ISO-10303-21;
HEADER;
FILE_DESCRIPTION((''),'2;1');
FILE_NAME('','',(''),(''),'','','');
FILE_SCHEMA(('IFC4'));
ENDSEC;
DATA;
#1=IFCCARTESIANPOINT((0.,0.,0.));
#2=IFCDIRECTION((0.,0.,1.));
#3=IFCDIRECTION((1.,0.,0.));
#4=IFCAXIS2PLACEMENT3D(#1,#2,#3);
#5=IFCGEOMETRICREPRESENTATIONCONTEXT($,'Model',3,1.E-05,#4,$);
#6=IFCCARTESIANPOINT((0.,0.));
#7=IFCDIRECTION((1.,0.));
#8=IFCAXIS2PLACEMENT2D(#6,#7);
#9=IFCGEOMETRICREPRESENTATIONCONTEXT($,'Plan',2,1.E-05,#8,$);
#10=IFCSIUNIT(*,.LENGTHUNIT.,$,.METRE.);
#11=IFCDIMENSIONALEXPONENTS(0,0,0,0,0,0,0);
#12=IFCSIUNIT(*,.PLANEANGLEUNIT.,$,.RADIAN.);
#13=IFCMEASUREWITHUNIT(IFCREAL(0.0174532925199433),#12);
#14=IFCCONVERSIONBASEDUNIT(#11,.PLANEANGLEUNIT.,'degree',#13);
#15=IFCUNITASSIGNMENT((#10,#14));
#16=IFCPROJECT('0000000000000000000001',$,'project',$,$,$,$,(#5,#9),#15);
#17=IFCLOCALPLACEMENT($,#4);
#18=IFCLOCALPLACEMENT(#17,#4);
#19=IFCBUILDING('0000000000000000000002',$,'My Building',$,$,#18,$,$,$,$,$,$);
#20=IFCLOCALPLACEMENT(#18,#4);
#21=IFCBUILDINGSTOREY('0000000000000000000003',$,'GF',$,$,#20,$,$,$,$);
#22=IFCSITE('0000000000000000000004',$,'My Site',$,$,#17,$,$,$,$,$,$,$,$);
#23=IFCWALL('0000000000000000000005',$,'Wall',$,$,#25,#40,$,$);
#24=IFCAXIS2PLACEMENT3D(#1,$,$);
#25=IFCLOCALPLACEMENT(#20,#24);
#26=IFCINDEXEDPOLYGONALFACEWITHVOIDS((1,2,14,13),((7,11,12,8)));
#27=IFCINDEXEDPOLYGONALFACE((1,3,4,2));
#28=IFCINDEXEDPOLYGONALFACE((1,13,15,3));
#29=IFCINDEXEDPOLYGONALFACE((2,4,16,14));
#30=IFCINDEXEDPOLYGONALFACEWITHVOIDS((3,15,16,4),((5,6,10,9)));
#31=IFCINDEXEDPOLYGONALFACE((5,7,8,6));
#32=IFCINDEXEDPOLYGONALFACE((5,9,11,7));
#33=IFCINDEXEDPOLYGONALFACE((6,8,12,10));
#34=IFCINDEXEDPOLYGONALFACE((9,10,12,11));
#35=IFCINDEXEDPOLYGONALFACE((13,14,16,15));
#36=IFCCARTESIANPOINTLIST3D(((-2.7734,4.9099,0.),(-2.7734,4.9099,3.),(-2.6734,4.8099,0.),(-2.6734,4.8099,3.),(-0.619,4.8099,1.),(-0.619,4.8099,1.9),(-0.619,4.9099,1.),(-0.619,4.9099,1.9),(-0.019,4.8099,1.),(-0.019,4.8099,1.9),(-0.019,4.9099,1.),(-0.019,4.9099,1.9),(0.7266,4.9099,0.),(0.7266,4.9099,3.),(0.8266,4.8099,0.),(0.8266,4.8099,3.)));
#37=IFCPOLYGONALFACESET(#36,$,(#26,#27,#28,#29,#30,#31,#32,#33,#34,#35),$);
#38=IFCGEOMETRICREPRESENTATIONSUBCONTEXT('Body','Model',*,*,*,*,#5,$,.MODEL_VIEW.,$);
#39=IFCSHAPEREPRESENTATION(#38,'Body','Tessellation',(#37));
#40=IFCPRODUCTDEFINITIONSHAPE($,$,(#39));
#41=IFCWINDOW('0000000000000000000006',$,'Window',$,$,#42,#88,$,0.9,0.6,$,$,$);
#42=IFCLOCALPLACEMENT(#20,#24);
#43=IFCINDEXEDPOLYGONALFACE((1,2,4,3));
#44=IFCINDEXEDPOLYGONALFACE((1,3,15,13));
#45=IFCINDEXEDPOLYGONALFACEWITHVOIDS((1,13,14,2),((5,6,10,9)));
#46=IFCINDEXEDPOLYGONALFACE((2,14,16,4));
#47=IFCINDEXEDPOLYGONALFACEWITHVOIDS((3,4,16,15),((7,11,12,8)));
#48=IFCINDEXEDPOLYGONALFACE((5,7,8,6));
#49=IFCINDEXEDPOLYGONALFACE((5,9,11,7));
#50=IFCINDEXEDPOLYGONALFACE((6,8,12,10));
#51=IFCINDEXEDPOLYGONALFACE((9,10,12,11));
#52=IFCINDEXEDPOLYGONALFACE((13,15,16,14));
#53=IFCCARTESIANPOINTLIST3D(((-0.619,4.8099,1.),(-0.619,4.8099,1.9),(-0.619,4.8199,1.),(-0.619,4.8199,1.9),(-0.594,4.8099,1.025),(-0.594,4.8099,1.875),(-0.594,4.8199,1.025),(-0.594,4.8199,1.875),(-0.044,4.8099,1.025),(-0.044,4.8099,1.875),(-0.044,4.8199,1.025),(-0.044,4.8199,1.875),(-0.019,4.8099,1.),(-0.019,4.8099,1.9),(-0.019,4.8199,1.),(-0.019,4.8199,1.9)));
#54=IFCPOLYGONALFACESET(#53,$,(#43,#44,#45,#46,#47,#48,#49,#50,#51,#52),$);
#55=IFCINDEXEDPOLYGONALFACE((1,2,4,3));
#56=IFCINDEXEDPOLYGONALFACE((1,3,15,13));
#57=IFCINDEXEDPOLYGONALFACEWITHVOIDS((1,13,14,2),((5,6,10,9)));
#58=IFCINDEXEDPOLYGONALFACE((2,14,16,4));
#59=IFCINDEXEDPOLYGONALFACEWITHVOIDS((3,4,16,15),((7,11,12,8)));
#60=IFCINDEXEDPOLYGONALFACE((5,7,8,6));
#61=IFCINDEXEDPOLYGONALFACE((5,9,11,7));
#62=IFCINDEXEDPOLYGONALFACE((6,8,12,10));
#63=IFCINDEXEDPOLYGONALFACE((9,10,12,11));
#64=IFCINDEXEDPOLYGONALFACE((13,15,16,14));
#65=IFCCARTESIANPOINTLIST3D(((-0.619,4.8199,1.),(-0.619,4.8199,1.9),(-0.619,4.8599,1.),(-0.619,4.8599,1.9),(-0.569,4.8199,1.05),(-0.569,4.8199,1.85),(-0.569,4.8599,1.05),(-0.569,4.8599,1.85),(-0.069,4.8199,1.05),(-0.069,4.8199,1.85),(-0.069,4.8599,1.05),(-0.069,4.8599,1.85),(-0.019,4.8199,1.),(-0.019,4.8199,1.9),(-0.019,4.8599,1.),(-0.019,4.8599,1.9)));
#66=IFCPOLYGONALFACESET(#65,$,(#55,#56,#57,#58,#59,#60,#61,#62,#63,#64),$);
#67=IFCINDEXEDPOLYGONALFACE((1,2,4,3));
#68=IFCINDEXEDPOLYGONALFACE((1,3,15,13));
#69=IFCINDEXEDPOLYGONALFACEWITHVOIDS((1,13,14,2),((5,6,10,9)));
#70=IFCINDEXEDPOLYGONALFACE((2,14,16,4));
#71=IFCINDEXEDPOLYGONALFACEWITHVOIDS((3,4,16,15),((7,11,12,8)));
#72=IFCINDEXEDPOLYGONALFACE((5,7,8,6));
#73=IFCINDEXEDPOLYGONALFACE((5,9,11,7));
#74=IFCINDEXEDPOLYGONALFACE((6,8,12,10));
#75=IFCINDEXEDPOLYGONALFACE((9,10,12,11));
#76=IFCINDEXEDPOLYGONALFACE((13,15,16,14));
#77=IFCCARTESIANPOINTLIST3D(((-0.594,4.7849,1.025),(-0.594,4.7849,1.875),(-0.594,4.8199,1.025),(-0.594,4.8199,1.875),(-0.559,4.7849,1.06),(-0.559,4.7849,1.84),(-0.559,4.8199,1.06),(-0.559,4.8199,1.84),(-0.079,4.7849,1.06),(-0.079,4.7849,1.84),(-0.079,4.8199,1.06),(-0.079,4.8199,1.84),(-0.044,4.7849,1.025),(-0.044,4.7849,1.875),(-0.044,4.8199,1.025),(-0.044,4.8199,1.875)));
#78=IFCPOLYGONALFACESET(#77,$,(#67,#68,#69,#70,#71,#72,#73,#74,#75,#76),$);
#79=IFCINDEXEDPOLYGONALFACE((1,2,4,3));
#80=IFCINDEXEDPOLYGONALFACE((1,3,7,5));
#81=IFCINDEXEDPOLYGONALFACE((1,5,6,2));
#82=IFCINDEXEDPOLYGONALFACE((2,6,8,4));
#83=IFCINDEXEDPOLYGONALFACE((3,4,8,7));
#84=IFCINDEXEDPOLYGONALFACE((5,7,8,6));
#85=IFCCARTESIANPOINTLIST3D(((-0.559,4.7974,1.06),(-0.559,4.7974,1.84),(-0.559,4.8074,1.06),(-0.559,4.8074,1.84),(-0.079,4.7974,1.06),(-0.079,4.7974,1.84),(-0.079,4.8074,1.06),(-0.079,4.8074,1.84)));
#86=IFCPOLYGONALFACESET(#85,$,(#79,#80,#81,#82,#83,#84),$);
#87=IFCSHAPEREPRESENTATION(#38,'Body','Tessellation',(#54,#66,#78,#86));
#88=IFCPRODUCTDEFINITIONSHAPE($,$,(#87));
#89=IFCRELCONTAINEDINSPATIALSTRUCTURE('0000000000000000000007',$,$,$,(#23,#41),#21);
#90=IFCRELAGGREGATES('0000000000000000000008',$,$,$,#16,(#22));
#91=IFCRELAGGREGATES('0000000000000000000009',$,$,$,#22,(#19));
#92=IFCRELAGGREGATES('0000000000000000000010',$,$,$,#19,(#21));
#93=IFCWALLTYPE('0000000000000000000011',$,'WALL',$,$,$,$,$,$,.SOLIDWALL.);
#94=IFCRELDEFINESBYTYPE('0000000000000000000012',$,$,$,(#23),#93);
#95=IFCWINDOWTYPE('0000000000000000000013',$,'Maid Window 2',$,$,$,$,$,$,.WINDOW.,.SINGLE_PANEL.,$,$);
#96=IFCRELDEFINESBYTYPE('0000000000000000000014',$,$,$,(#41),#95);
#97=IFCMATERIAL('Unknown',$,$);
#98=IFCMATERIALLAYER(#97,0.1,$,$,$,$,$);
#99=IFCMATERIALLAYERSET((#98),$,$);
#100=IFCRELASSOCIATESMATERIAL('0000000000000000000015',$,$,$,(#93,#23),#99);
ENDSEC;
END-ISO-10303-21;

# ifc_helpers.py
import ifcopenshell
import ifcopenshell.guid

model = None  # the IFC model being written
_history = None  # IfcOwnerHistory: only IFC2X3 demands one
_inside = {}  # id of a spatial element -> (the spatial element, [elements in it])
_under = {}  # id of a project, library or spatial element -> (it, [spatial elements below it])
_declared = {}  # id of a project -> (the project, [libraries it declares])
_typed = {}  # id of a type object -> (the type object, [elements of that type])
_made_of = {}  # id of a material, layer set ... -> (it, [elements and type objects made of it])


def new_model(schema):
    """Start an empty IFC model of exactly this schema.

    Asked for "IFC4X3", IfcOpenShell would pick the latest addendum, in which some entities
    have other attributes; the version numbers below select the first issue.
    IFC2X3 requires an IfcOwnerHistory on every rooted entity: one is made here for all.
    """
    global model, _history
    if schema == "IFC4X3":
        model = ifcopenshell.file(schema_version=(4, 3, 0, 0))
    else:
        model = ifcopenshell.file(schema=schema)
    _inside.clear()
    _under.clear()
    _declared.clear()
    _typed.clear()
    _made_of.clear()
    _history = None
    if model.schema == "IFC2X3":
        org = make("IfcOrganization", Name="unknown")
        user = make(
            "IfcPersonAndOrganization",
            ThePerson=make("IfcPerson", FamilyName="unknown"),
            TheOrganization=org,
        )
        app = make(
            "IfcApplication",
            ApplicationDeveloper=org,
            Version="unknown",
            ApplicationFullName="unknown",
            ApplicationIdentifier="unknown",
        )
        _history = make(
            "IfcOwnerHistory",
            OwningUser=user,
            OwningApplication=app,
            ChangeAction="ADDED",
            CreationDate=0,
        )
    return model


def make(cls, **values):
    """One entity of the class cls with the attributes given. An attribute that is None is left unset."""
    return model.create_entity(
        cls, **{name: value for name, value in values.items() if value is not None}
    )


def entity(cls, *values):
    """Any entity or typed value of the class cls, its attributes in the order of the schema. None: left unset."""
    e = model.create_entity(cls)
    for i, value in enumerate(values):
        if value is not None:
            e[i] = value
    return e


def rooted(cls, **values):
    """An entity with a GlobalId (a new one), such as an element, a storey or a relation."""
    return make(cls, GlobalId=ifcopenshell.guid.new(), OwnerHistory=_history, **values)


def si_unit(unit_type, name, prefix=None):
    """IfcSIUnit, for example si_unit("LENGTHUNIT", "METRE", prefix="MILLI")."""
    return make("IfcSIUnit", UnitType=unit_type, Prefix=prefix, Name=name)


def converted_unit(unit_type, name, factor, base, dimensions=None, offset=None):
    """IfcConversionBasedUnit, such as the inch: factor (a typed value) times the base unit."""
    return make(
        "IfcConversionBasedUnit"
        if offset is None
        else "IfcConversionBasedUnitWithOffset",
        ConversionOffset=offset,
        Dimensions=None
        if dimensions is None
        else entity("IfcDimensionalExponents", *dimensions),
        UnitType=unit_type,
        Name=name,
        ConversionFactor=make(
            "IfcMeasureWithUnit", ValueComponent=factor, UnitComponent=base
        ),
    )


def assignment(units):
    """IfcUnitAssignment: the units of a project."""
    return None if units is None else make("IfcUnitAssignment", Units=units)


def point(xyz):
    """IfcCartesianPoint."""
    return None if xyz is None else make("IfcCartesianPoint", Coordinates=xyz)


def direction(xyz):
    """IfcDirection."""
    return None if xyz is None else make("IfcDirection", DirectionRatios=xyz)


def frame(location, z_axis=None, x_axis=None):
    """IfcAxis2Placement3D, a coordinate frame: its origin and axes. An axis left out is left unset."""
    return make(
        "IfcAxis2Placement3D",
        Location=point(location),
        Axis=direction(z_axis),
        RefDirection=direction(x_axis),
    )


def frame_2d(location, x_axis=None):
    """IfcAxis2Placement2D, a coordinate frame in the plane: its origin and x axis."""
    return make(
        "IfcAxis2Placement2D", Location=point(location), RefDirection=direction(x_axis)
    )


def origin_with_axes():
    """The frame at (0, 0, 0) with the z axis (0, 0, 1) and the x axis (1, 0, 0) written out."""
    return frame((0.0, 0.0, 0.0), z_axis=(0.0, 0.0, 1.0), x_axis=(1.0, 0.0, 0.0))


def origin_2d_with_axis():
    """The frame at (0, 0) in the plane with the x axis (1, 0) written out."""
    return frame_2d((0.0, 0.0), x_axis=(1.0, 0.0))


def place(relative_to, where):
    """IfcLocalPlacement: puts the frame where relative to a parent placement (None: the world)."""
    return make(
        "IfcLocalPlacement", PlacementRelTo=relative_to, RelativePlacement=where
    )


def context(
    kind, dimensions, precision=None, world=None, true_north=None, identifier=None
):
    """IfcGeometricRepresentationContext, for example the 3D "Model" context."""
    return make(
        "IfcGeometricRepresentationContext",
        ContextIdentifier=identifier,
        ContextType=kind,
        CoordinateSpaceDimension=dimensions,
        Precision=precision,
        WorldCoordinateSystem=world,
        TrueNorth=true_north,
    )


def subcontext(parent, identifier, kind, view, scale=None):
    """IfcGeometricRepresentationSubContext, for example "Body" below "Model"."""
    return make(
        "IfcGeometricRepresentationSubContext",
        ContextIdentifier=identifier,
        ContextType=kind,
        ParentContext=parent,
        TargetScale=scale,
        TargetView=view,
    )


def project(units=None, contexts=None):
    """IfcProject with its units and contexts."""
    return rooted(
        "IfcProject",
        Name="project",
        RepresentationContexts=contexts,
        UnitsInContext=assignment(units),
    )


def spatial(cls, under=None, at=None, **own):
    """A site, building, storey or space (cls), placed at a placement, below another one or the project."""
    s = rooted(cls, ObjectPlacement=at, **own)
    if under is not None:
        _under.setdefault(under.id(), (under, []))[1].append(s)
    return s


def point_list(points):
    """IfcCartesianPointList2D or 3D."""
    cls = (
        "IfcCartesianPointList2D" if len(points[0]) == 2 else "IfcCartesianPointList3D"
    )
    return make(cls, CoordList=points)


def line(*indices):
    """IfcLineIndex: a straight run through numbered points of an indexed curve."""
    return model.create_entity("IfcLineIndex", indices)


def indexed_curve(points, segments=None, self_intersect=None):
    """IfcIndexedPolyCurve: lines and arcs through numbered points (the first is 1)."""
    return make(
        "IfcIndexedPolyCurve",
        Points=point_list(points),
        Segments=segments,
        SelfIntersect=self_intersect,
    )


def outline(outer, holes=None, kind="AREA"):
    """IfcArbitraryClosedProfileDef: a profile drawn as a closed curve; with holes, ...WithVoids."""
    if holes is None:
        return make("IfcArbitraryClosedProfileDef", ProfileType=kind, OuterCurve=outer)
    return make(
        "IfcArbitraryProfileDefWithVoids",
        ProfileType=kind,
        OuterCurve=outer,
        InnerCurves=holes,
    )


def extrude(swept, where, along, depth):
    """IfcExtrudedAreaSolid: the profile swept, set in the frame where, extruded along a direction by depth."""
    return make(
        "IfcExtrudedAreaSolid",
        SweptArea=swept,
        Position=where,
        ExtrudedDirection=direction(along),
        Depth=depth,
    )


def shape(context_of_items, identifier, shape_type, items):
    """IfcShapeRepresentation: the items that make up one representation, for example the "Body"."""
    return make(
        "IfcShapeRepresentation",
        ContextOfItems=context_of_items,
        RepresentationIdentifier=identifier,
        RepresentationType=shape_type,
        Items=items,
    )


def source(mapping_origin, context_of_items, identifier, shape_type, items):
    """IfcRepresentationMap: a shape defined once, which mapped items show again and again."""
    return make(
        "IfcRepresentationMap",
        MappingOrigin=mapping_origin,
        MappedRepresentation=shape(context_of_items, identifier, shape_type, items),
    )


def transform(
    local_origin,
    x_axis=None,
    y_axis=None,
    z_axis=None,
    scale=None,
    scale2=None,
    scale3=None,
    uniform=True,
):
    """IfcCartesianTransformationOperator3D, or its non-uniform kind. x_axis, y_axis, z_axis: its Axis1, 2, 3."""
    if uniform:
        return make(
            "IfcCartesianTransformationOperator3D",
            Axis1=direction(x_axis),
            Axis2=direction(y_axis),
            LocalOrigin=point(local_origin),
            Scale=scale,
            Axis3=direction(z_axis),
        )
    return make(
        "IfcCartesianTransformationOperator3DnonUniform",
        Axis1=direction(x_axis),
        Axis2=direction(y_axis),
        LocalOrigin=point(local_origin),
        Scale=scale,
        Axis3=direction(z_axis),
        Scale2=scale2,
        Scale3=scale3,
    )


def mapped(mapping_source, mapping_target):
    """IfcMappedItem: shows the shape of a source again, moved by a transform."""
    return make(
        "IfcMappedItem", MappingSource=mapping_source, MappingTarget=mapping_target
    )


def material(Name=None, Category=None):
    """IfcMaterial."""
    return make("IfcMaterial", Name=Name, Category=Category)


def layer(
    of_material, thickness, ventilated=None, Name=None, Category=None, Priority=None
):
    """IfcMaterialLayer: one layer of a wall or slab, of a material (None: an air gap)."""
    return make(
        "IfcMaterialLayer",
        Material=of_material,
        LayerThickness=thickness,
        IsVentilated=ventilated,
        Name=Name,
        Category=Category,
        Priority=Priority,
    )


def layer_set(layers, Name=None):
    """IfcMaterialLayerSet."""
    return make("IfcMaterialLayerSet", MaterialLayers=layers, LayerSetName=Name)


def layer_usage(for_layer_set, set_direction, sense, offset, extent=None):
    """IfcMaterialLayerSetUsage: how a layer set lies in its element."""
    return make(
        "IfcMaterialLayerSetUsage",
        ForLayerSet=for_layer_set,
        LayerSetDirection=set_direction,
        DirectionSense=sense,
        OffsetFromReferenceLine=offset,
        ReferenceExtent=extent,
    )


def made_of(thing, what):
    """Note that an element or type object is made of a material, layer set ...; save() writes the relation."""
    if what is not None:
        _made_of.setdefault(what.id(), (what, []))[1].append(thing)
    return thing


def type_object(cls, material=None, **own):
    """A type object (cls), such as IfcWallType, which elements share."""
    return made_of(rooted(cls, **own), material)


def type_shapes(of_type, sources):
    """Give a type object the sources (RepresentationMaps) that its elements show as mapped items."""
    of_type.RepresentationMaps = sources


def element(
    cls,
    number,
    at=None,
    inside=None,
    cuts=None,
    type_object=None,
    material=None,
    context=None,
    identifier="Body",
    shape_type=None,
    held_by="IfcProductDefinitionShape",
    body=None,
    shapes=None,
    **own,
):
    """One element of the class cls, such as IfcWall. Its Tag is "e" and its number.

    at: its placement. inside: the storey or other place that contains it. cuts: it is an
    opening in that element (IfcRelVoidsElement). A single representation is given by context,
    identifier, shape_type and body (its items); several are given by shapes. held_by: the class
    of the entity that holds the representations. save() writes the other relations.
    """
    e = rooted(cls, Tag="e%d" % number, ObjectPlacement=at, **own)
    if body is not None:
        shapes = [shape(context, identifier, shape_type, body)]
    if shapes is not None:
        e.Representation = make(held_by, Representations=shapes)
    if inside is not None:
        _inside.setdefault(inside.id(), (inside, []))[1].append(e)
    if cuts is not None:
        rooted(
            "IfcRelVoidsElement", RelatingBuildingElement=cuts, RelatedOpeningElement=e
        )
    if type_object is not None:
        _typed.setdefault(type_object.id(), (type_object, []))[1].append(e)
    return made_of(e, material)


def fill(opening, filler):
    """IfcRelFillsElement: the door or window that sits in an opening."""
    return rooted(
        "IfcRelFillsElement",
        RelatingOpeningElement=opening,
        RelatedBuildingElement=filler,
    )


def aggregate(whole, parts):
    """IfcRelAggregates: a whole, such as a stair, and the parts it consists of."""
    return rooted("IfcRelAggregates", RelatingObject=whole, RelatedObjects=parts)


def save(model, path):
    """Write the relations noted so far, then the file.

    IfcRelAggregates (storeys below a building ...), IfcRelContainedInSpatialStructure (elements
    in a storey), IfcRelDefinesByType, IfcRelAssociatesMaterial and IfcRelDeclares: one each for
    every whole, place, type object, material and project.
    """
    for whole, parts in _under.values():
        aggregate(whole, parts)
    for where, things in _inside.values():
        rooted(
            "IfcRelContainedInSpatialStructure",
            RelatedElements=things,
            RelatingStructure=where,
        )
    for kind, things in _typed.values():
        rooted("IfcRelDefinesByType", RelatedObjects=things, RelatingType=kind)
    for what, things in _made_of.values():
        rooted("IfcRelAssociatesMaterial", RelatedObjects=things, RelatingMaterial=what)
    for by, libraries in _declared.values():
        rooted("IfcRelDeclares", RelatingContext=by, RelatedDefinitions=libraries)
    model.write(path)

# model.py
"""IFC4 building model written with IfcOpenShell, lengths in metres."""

from ifc_helpers import new_model, entity, si_unit, converted_unit, frame, origin_with_axes, origin_2d_with_axis, place, context, subcontext, project, spatial, line, indexed_curve, outline, extrude, shape, source, transform, mapped, material, layer, layer_set, layer_usage, type_object, type_shapes, element, fill, save


model = new_model("IFC4")

# Units and contexts
model_context = context("Model", 3, precision=1e-05, world=origin_with_axes())
plan_context = context("Plan", 2, precision=1e-05, world=origin_2d_with_axis())
body_context_1 = subcontext(model_context, "Body", "Model", "MODEL_VIEW")
body_context_2 = subcontext(plan_context, "Body", "Plan", "PLAN_VIEW")
ifc_project = project(units=[si_unit("LENGTHUNIT", "METRE"), converted_unit("PLANEANGLEUNIT", "degree", entity("IfcReal", 0.0174532925199433), si_unit("PLANEANGLEUNIT", "RADIAN"), dimensions=[0, 0, 0, 0, 0, 0, 0])], contexts=[model_context, plan_context])

# Site, building, storey
site_placement = place(None, origin_with_axes())
site = spatial("IfcSite", under=ifc_project, at=site_placement, Name="My Site")
building_placement = place(site_placement, origin_with_axes())
building = spatial("IfcBuilding", under=site, at=building_placement, Name="My Building")
storey_placement = place(building_placement, origin_with_axes())
storey = spatial("IfcBuildingStorey", under=building, at=storey_placement, Name="GF")

# Shared definitions
ifc_material = material(Name="Unknown")

# Shared definitions
ifc_layer_1 = layer(ifc_material, 0.1)
ifc_layer_set_1 = layer_set([ifc_layer_1])
wall_type = type_object("IfcWallType", Name="WALL", PredefinedType="SOLIDWALL", material=ifc_layer_set_1)

# Wall, opening, window
ifc_layer_usage_1 = layer_usage(ifc_layer_set_1, "AXIS2", "POSITIVE", 0.0)
wall_1_placement = place(storey_placement, frame((0.7266, 4.9099, 0.0), z_axis=(0.0, 0.0, 1.0), x_axis=(-1.0, 0.0, 0.0)))
wall_1 = element("IfcWall", 1, at=wall_1_placement, inside=storey, type_object=wall_type, material=ifc_layer_usage_1, Name="Wall", context=body_context_1, shape_type="SweptSolid", body=[
    extrude(outline(indexed_curve([(0.0, 0.0), (-0.1, 0.1), (3.4, 0.1), (3.5, 0.0)], segments=[line(1, 2, 3, 4, 1)])), origin_with_axes(), (0.0, 0.0, 1.0), 3.0),
])
shared_shape_1 = source(origin_with_axes(), body_context_1, "Body", "SweptSolid", [
    extrude(outline(indexed_curve([(0.0, 0.0), (0.6, 0.0), (0.6, 0.9), (0.0, 0.9)], segments=[line(1, 2, 3, 4, 1)])), frame((0.0, -0.6, 0.0), z_axis=(0.0, -1.0, 0.0), x_axis=(1.0, 0.0, 0.0)), (0.0, 0.0, -1.0), 1.2),
])
opening_1_placement = place(wall_1_placement, frame((0.7456, 0.0, 1.0), z_axis=(0.0, 0.0, 1.0), x_axis=(1.0, 0.0, 0.0)))
opening_1 = element("IfcOpeningElement", 2, at=opening_1_placement, cuts=wall_1, PredefinedType="OPENING", context=body_context_1, shape_type="MappedRepresentation", body=[
    mapped(shared_shape_1, transform((0.0, 0.0, 0.0), x_axis=(1.0, 0.0, 0.0), y_axis=(0.0, 1.0, 0.0), z_axis=(0.0, 0.0, 1.0), scale=1.0)),
])
window_type_1 = type_object("IfcWindowType", Name="Maid Window 2", PartitioningType="SINGLE_PANEL", PredefinedType="WINDOW")
shared_shape_2 = source(origin_with_axes(), body_context_1, "Body", "SweptSolid", [
    extrude(outline(indexed_curve([(0.0, 0.0), (0.6, 0.0), (0.6, 0.9), (0.0, 0.9)], segments=[line(1, 2, 3, 4, 1)]), holes=[indexed_curve([(0.025, 0.025), (0.575, 0.025), (0.575, 0.875), (0.025, 0.875)], segments=[line(1, 2, 3, 4, 1)])]), frame((0.0, 0.09, 0.0), z_axis=(0.0, -1.0, 0.0), x_axis=(1.0, 0.0, 0.0)), (0.0, 0.0, -1.0), 0.01),
    extrude(outline(indexed_curve([(0.0, 0.0), (0.6, 0.0), (0.6, 0.9), (0.0, 0.9)], segments=[line(1, 2, 3, 4, 1)]), holes=[indexed_curve([(0.05, 0.05), (0.55, 0.05), (0.55, 0.85), (0.05, 0.85)], segments=[line(1, 2, 3, 4, 1)])]), frame((0.0, 0.05, 0.0), z_axis=(0.0, -1.0, 0.0), x_axis=(1.0, 0.0, 0.0)), (0.0, 0.0, -1.0), 0.04),
    extrude(outline(indexed_curve([(0.0, 0.0), (0.55, 0.0), (0.55, 0.85), (0.0, 0.85)], segments=[line(1, 2, 3, 4, 1)]), holes=[indexed_curve([(0.035, 0.035), (0.515, 0.035), (0.515, 0.815), (0.035, 0.815)], segments=[line(1, 2, 3, 4, 1)])]), frame((0.025, 0.09, 0.025), z_axis=(0.0, -1.0, 0.0), x_axis=(1.0, 0.0, 0.0)), (0.0, 0.0, -1.0), 0.035),
    extrude(outline(indexed_curve([(0.035, 0.035), (0.515, 0.035), (0.515, 0.815), (0.035, 0.815)], segments=[line(1, 2, 3, 4, 1)])), frame((0.025, 0.1025, 0.025), z_axis=(0.0, -1.0, 0.0), x_axis=(1.0, 0.0, 0.0)), (0.0, 0.0, -1.0), 0.01),
])
shared_shape_3 = source(origin_with_axes(), body_context_2, "Body", "Curve2D", [
    entity("IfcIndexedPolyCurve", entity("IfcCartesianPointList2D", [[0.05, 0.05], [0.55, 0.05]])),
    entity("IfcIndexedPolyCurve", entity("IfcCartesianPointList2D", [[0.0, 0.1], [0.025, 0.1], [0.025, 0.09], [0.05, 0.09], [0.05, 0.05], [0.0, 0.05]]), [entity("IfcLineIndex", [1, 2, 3, 4, 5, 6, 1])]),
    entity("IfcIndexedPolyCurve", entity("IfcCartesianPointList2D", [[0.6, 0.1], [0.575, 0.1], [0.575, 0.09], [0.55, 0.09], [0.55, 0.05], [0.6, 0.05]]), [entity("IfcLineIndex", [1, 2, 3, 4, 5, 6, 1])]),
    entity("IfcIndexedPolyCurve", entity("IfcCartesianPointList2D", [[0.025, 0.09], [0.06, 0.09], [0.06, 0.125], [0.025, 0.125]]), [entity("IfcLineIndex", [1, 2, 3, 4, 1])]),
    entity("IfcIndexedPolyCurve", entity("IfcCartesianPointList2D", [[0.575, 0.09], [0.54, 0.09], [0.54, 0.125], [0.575, 0.125]]), [entity("IfcLineIndex", [1, 2, 3, 4, 1])]),
    entity("IfcIndexedPolyCurve", entity("IfcCartesianPointList2D", [[0.06, 0.09], [0.54, 0.09]])),
    entity("IfcIndexedPolyCurve", entity("IfcCartesianPointList2D", [[0.06, 0.125], [0.54, 0.125]])),
    entity("IfcIndexedPolyCurve", entity("IfcCartesianPointList2D", [[0.06, 0.1075], [0.54, 0.1075]])),
])
type_shapes(window_type_1, [shared_shape_2, shared_shape_3])
window_1_placement = place(opening_1_placement, frame((0.0, 0.0, 0.0), z_axis=(0.0, 0.0, 1.0), x_axis=(1.0, 0.0, 0.0)))
window_1 = element("IfcWindow", 3, at=window_1_placement, inside=storey, type_object=window_type_1, Name="Window", OverallHeight=0.9, OverallWidth=0.6, shapes=[
    shape(body_context_1, "Body", "MappedRepresentation", [mapped(shared_shape_2, transform((0.0, 0.0, 0.0), x_axis=(1.0, 0.0, 0.0), y_axis=(0.0, 1.0, 0.0), z_axis=(0.0, 0.0, 1.0), scale=1.0))]),
    shape(body_context_2, "Body", "MappedRepresentation", [mapped(shared_shape_3, transform((0.0, 0.0, 0.0), x_axis=(1.0, 0.0, 0.0), y_axis=(0.0, 1.0, 0.0), z_axis=(0.0, 0.0, 1.0), scale=1.0))]),
])
fill(opening_1, window_1)

save(model, "model.ifc")
